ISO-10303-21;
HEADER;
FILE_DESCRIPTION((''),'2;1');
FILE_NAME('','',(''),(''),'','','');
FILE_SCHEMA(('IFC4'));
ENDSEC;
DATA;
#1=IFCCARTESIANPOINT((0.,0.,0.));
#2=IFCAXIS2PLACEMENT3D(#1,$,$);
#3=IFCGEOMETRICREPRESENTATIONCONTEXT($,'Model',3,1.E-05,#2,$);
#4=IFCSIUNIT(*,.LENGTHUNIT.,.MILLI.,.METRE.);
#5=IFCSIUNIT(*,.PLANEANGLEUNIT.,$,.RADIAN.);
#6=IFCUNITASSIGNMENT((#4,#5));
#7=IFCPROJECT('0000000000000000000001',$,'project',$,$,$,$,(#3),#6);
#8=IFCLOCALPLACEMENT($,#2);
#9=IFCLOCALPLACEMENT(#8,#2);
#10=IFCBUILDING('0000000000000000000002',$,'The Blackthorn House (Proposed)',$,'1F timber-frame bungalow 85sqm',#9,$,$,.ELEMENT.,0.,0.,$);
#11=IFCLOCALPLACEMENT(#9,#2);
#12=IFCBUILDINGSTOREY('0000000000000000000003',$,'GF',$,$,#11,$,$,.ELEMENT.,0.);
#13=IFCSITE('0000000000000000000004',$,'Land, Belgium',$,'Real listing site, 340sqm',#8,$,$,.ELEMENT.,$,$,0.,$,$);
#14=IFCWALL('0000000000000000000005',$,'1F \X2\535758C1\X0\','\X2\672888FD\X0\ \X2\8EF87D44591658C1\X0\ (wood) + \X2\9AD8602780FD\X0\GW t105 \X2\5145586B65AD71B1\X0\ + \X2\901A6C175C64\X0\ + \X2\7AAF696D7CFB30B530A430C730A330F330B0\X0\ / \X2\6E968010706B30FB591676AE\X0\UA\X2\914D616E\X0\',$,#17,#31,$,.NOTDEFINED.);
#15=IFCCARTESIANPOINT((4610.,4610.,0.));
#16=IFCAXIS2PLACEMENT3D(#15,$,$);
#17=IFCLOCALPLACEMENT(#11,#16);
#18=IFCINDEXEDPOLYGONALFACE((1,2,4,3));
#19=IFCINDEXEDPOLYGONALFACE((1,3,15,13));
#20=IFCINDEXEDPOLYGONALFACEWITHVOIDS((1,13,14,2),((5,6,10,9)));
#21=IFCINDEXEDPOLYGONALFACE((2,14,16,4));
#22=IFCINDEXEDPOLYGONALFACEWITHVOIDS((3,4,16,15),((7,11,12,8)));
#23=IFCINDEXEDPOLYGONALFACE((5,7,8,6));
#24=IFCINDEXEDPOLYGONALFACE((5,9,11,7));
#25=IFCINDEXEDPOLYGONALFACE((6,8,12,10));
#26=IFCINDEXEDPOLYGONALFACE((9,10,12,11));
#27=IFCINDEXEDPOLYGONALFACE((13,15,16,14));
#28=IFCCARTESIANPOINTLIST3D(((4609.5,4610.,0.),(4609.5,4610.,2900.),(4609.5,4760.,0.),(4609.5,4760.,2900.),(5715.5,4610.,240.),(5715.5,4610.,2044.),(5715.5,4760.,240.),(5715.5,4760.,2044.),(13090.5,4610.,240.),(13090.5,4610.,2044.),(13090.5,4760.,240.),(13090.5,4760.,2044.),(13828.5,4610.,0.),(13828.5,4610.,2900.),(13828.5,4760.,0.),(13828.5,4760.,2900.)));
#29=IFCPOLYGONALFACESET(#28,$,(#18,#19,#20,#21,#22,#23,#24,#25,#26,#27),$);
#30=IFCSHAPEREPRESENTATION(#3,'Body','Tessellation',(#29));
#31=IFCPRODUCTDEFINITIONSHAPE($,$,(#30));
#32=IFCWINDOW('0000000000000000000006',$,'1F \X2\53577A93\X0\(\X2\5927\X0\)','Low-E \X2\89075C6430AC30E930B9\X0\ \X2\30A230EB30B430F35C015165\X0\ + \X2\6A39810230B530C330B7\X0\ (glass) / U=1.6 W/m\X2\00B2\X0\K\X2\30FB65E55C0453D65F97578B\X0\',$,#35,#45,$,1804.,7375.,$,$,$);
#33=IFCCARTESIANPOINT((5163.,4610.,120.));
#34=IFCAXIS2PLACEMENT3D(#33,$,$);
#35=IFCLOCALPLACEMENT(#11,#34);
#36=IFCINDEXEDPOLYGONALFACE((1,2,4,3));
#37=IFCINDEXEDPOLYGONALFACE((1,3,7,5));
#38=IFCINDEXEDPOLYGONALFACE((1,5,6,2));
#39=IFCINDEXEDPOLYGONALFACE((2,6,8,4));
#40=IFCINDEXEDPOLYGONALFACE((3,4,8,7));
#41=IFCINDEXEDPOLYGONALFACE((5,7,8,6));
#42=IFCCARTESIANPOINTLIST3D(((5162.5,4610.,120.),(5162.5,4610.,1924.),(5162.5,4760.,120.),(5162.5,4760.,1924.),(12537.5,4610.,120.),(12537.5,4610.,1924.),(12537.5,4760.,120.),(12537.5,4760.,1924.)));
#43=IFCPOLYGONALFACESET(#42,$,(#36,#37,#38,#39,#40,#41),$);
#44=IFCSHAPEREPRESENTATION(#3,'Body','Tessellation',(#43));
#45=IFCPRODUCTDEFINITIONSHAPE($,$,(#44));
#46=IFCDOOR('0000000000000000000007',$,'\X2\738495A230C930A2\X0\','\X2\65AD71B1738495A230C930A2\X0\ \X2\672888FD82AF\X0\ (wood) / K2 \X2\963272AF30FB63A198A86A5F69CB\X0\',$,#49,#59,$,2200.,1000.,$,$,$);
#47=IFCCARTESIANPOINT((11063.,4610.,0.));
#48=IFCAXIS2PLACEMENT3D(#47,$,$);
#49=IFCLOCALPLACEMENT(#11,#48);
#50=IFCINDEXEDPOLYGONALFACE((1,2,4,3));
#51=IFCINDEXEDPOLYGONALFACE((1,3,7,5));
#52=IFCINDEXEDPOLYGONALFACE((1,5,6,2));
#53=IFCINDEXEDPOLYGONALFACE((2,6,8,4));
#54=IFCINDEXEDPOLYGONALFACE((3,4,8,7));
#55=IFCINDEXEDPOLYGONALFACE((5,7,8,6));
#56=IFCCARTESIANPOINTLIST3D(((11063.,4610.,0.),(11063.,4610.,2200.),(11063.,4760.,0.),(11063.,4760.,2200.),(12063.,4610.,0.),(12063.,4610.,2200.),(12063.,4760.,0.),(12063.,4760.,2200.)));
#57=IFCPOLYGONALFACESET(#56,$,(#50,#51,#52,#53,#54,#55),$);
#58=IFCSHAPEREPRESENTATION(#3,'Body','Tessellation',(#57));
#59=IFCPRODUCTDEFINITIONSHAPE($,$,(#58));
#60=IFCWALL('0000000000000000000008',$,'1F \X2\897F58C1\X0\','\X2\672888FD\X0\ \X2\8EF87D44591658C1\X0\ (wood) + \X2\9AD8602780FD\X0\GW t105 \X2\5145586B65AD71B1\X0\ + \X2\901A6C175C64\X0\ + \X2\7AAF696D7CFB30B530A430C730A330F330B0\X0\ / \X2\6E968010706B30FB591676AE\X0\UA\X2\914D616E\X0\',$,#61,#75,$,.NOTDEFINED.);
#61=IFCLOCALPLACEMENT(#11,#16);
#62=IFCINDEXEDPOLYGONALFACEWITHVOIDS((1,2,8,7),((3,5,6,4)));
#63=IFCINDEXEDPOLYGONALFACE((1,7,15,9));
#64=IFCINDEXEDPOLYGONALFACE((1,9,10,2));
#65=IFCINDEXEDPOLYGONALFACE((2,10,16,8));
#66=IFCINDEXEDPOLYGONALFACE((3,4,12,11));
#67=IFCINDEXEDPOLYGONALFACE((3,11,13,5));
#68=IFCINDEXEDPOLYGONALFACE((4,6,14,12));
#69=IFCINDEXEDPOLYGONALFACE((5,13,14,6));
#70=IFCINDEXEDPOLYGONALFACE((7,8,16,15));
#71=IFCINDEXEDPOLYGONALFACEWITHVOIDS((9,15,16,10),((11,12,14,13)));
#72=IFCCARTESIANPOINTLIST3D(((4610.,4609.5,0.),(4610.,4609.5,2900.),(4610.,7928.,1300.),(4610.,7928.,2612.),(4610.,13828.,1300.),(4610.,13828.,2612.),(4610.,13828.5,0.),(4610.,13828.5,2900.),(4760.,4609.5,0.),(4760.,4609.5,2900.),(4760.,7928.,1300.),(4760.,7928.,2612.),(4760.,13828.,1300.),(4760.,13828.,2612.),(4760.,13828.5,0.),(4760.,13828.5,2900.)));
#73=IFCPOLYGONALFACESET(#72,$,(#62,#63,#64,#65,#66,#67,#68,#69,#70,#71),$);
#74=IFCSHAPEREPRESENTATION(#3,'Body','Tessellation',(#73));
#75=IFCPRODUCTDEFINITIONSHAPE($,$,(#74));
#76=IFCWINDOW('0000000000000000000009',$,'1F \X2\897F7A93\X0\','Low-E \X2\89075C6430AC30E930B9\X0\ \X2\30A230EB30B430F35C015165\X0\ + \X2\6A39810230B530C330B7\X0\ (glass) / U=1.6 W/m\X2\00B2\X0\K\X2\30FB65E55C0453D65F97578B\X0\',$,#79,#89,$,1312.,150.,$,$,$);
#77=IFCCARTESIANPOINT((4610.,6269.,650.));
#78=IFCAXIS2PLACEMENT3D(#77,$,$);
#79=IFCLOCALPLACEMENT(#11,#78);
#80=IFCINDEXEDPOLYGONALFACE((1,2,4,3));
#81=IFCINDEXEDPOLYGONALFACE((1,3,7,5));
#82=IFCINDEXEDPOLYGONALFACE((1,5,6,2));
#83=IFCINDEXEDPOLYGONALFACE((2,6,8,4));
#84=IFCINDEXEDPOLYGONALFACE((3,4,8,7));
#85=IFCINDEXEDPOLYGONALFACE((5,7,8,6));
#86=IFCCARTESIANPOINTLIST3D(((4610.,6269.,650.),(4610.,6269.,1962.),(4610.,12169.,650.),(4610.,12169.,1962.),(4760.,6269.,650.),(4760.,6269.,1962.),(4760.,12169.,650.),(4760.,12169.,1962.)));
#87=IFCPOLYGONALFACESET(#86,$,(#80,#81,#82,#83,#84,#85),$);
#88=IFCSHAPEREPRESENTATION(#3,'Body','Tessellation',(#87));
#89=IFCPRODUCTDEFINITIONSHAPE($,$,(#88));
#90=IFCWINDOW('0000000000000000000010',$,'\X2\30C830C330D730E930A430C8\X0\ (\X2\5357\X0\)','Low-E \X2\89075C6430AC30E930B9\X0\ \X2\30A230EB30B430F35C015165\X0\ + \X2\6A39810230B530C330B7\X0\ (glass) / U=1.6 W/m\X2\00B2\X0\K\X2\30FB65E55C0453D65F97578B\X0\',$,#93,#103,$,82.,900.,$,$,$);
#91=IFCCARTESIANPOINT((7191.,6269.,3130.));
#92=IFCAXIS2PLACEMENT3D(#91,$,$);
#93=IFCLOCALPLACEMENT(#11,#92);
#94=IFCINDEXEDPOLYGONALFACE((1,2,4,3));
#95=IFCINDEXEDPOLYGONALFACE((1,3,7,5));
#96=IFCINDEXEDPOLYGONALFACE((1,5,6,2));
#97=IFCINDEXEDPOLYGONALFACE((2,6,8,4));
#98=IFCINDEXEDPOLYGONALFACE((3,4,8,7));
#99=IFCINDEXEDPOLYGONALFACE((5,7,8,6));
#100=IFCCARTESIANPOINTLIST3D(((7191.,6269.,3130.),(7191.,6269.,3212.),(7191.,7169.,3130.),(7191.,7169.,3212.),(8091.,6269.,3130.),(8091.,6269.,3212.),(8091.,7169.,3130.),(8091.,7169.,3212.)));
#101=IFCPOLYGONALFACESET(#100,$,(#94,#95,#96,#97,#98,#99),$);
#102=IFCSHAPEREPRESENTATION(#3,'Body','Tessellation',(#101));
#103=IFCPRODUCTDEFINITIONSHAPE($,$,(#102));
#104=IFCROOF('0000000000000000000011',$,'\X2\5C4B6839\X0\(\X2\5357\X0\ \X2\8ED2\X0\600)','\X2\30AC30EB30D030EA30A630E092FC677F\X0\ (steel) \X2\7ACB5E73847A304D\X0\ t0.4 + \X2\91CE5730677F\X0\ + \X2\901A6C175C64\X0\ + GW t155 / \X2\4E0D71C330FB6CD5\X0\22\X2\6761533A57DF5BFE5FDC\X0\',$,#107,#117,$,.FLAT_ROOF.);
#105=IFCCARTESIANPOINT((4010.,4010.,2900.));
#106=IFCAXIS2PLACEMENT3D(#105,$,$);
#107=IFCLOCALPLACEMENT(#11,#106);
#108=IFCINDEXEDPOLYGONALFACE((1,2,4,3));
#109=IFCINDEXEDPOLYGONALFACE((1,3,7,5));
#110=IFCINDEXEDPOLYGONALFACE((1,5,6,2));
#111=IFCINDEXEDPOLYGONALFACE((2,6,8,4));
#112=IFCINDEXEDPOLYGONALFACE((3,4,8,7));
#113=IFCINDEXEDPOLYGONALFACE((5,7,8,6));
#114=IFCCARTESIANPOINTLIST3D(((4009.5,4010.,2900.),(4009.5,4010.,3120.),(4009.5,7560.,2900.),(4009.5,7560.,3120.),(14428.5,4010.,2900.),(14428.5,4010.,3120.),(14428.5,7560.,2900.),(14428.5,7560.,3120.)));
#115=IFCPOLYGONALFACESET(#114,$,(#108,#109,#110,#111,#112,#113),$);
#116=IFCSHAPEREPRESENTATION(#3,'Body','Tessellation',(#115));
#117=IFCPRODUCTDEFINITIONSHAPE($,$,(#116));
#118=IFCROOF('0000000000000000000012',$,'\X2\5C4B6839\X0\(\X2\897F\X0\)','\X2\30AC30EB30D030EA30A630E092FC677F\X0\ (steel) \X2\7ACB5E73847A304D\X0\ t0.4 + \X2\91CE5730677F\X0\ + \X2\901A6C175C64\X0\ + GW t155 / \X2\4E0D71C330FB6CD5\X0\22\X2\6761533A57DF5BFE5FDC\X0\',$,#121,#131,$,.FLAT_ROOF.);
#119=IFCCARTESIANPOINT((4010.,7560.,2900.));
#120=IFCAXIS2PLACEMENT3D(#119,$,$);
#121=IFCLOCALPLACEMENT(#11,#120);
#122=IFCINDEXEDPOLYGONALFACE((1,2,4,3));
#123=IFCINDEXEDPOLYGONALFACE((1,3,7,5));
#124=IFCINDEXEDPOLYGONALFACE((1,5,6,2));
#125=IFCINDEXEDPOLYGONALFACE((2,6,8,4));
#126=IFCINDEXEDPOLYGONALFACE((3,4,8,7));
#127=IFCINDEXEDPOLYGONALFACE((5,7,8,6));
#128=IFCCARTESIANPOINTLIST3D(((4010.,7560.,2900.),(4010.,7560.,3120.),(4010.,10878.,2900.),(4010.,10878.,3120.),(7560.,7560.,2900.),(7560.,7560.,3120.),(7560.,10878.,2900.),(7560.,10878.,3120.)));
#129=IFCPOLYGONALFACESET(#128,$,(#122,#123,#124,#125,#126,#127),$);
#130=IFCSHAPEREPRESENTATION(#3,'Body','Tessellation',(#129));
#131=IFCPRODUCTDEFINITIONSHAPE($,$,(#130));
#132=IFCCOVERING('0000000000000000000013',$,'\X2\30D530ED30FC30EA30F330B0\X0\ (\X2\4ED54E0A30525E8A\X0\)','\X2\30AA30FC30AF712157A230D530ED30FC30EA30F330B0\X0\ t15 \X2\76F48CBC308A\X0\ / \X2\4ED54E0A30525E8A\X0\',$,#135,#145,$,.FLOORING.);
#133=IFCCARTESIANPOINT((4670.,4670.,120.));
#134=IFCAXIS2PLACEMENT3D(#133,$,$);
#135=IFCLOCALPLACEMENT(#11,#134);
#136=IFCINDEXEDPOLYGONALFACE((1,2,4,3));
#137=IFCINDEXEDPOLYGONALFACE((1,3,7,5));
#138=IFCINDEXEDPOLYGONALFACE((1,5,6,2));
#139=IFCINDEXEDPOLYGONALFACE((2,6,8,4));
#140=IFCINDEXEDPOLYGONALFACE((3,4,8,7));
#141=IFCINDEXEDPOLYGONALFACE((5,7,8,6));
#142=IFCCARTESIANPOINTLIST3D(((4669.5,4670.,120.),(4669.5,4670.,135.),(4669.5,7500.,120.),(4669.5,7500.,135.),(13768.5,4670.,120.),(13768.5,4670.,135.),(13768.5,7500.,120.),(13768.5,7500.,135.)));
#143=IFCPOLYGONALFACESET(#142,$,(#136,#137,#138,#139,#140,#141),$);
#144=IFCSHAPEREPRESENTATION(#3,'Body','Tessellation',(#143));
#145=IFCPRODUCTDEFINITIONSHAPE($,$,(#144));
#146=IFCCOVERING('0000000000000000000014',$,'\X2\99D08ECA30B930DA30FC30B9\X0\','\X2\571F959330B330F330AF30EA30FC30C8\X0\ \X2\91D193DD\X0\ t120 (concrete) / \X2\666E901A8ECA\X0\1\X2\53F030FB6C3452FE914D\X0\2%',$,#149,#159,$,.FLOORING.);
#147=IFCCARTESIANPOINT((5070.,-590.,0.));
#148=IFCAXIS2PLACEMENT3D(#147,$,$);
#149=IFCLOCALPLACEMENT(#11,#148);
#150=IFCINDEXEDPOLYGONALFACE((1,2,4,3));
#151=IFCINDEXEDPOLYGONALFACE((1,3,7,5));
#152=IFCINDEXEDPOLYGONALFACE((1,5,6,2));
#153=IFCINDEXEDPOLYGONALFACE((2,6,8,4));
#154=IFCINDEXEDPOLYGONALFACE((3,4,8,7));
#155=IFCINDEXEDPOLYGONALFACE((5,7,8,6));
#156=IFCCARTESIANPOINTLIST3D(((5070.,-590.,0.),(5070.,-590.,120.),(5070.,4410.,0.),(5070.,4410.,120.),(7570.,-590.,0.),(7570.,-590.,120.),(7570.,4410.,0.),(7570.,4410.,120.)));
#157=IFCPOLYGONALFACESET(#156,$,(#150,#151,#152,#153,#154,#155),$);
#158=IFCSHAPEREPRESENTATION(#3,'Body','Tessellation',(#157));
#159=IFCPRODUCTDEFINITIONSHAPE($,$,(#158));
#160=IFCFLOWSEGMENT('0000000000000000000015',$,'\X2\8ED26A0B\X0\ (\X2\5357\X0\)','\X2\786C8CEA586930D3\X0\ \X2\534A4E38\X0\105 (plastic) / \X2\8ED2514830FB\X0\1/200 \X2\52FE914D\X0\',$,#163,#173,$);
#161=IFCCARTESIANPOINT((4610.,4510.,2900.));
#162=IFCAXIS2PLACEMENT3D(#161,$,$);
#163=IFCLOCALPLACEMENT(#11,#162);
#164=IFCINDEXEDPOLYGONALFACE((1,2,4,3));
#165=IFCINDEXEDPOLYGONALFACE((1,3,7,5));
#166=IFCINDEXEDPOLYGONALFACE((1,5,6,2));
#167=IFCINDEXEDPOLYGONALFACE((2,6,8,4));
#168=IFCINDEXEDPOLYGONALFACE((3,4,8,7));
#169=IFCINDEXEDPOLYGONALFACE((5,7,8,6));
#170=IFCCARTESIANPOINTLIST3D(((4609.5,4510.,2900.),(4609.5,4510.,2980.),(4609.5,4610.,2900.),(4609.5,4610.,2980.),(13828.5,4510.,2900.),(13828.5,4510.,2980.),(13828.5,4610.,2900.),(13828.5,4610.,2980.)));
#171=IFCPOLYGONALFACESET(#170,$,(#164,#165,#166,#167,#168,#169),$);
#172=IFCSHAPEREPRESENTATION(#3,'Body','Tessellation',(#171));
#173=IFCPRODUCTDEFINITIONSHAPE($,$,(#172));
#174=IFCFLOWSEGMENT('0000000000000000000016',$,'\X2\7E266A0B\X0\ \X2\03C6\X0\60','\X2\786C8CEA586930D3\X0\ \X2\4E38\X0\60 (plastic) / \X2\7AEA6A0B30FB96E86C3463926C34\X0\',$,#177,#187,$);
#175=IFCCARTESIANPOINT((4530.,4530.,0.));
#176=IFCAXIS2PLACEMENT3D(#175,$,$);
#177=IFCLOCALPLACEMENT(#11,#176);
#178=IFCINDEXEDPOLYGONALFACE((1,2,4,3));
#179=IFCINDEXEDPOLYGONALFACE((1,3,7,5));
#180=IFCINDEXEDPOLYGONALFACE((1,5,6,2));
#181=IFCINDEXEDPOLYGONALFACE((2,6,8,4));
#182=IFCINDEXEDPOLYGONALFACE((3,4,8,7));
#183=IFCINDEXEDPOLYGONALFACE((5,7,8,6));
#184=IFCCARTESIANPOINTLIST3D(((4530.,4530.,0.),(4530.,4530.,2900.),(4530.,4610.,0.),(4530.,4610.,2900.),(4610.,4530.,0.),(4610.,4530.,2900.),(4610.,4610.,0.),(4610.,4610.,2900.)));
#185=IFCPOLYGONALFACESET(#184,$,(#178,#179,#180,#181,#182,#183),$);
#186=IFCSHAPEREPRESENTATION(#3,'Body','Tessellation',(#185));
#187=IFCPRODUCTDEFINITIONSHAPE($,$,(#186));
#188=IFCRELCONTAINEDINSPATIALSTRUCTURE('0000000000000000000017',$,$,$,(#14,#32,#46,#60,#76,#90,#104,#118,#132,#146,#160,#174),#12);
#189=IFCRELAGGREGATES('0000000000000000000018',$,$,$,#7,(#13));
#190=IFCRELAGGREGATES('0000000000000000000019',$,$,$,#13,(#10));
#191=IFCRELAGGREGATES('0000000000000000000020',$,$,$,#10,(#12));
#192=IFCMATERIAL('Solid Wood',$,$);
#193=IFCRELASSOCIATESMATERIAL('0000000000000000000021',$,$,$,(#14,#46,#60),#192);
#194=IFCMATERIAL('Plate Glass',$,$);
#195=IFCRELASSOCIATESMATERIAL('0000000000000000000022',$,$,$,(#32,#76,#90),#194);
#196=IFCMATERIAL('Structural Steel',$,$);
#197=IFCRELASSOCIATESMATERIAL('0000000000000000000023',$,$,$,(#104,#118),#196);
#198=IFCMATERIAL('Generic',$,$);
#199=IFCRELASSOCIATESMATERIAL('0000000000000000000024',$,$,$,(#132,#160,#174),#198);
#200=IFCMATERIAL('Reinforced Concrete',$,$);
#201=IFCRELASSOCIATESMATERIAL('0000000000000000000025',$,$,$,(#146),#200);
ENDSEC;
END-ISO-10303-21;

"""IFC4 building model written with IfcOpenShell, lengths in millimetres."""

from ifc_helpers import new_model, si_unit, frame, frame_2d, origin, place, context, project, spatial, rectangle, extrude, material, element, fill, save


model = new_model("IFC4")

# Units and contexts
model_context = context("Model", 3, precision=1e-05, world=origin())
ifc_project = project(units=[si_unit("LENGTHUNIT", "METRE", prefix="MILLI"), si_unit("PLANEANGLEUNIT", "RADIAN")], contexts=[model_context])

# Site, building, storey
site_placement = place(None, origin())
site = spatial("IfcSite", under=ifc_project, at=site_placement, Name="Land, Belgium", ObjectType="Real listing site, 340sqm", CompositionType="ELEMENT", RefElevation=0.0)
building_placement = place(site_placement, origin())
building = spatial("IfcBuilding", under=site, at=building_placement, Name="The Blackthorn House (Proposed)", ObjectType="1F timber-frame bungalow 85sqm", CompositionType="ELEMENT", ElevationOfRefHeight=0.0, ElevationOfTerrain=0.0)
storey_placement = place(building_placement, origin())
storey = spatial("IfcBuildingStorey", under=building, at=storey_placement, Name="GF", CompositionType="ELEMENT", Elevation=0.0)

# Shared definitions
ifc_material_1 = material(Name="Solid Wood")

# Shared definitions
ifc_material_2 = material(Name="Reinforced Concrete")

# Wall, openings, window, door
wall_1_placement = place(storey_placement, frame((4610.0, 4610.0, 0.0)))
wall_1 = element("IfcWall", 1, at=wall_1_placement, inside=storey, material=ifc_material_1, Name="1F 南壁", Description="木製 軸組外壁 (wood) + 高性能GW t105 充填断熱 + 通気層 + 窯業系サイディング / 準耐火・外皮UA配慮", PredefinedType="NOTDEFINED", context=model_context, shape_type="SweptSolid", body=[
    extrude(rectangle(XDim=9219.0, YDim=150.0, at=frame_2d((4609.0, 75.0))), frame((4610.0, 4610.0, 0.0)), (0.0, 0.0, 1.0), 2900.0),
])
opening_1_placement = place(storey_placement, frame((5163.0, 4610.0, 120.0)))
opening_1 = element("IfcOpeningElement", 2, at=opening_1_placement, cuts=wall_1, PredefinedType="NOTDEFINED", context=model_context, shape_type="SweptSolid", body=[
    extrude(rectangle(XDim=7375.0, YDim=150.0, at=frame_2d((3687.0, 75.0))), frame((5163.0, 4610.0, 120.0)), (0.0, 0.0, 1.0), 1804.0),
])
opening_2_placement = place(storey_placement, frame((11063.0, 4610.0, 0.0)))
opening_2 = element("IfcOpeningElement", 3, at=opening_2_placement, cuts=wall_1, PredefinedType="NOTDEFINED", context=model_context, shape_type="SweptSolid", body=[
    extrude(rectangle(XDim=1000.0, YDim=150.0, at=frame_2d((500.0, 75.0))), frame((11063.0, 4610.0, 0.0)), (0.0, 0.0, 1.0), 2200.0),
])
ifc_material_3 = material(Name="Plate Glass")
window_1_placement = place(storey_placement, frame((5163.0, 4610.0, 120.0)))
window_1 = element("IfcWindow", 4, at=window_1_placement, inside=storey, material=ifc_material_3, Name="1F 南窓(大)", Description="Low-E 複層ガラス アルゴン封入 + 樹脂サッシ (glass) / U=1.6 W/m²K・日射取得型", OverallHeight=1804.0, OverallWidth=7375.0, context=model_context, shape_type="SweptSolid", body=[
    extrude(rectangle(XDim=7375.0, YDim=150.0, at=frame_2d((3687.0, 75.0))), frame((5163.0, 4610.0, 120.0)), (0.0, 0.0, 1.0), 1804.0),
])
fill(opening_1, window_1)
door_placement = place(storey_placement, frame((11063.0, 4610.0, 0.0)))
door = element("IfcDoor", 5, at=door_placement, inside=storey, material=ifc_material_1, Name="玄関ドア", Description="断熱玄関ドア 木製芯 (wood) / K2 防犯・採風機構", OverallHeight=2200.0, OverallWidth=1000.0, context=model_context, shape_type="SweptSolid", body=[
    extrude(rectangle(XDim=1000.0, YDim=150.0, at=frame_2d((500.0, 75.0))), frame((11063.0, 4610.0, 0.0)), (0.0, 0.0, 1.0), 2200.0),
])
fill(opening_2, door)

# Wall, opening, window
wall_2_placement = place(storey_placement, frame((4610.0, 4610.0, 0.0)))
wall_2 = element("IfcWall", 6, at=wall_2_placement, inside=storey, material=ifc_material_1, Name="1F 西壁", Description="木製 軸組外壁 (wood) + 高性能GW t105 充填断熱 + 通気層 + 窯業系サイディング / 準耐火・外皮UA配慮", PredefinedType="NOTDEFINED", context=model_context, shape_type="SweptSolid", body=[
    extrude(rectangle(XDim=150.0, YDim=9219.0, at=frame_2d((75.0, 4609.0))), frame((4610.0, 4610.0, 0.0)), (0.0, 0.0, 1.0), 2900.0),
])
opening_3_placement = place(storey_placement, frame((4610.0, 6269.0, 650.0)))
opening_3 = element("IfcOpeningElement", 7, at=opening_3_placement, cuts=wall_2, PredefinedType="NOTDEFINED", context=model_context, shape_type="SweptSolid", body=[
    extrude(rectangle(XDim=150.0, YDim=5900.0, at=frame_2d((75.0, 2950.0))), frame((4610.0, 6269.0, 650.0)), (0.0, 0.0, 1.0), 1312.0),
])
window_2_placement = place(storey_placement, frame((4610.0, 6269.0, 650.0)))
window_2 = element("IfcWindow", 8, at=window_2_placement, inside=storey, material=ifc_material_3, Name="1F 西窓", Description="Low-E 複層ガラス アルゴン封入 + 樹脂サッシ (glass) / U=1.6 W/m²K・日射取得型", OverallHeight=1312.0, OverallWidth=150.0, context=model_context, shape_type="SweptSolid", body=[
    extrude(rectangle(XDim=150.0, YDim=5900.0, at=frame_2d((75.0, 2950.0))), frame((4610.0, 6269.0, 650.0)), (0.0, 0.0, 1.0), 1312.0),
])
fill(opening_3, window_2)

# Window
window_3_placement = place(storey_placement, frame((7191.0, 6269.0, 3130.0)))
element("IfcWindow", 9, at=window_3_placement, inside=storey, material=ifc_material_3, Name="トップライト (南)", Description="Low-E 複層ガラス アルゴン封入 + 樹脂サッシ (glass) / U=1.6 W/m²K・日射取得型", OverallHeight=82.0, OverallWidth=900.0, context=model_context, shape_type="SweptSolid", body=[
    extrude(rectangle(XDim=900.0, YDim=900.0, at=frame_2d((450.0, 450.0))), frame((7191.0, 6269.0, 3130.0)), (0.0, 0.0, 1.0), 82.0),
])

# Roofs
ifc_material_4 = material(Name="Structural Steel")
roof_1_placement = place(storey_placement, frame((4010.0, 4010.0, 2900.0)))
element("IfcRoof", 10, at=roof_1_placement, inside=storey, material=ifc_material_4, Name="屋根(南 軒600)", Description="ガルバリウム鋼板 (steel) 立平葺き t0.4 + 野地板 + 通気層 + GW t155 / 不燃・法22条区域対応", PredefinedType="FLAT_ROOF", context=model_context, shape_type="SweptSolid", body=[
    extrude(rectangle(XDim=10419.0, YDim=3550.0, at=frame_2d((5209.0, 1775.0))), frame((4010.0, 4010.0, 2900.0)), (0.0, 0.0, 1.0), 220.0),
])
roof_2_placement = place(storey_placement, frame((4010.0, 7560.0, 2900.0)))
element("IfcRoof", 11, at=roof_2_placement, inside=storey, material=ifc_material_4, Name="屋根(西)", Description="ガルバリウム鋼板 (steel) 立平葺き t0.4 + 野地板 + 通気層 + GW t155 / 不燃・法22条区域対応", PredefinedType="FLAT_ROOF", context=model_context, shape_type="SweptSolid", body=[
    extrude(rectangle(XDim=3550.0, YDim=3318.0, at=frame_2d((1775.0, 1659.0))), frame((4010.0, 7560.0, 2900.0)), (0.0, 0.0, 1.0), 220.0),
])

# Coverings
ifc_material_5 = material(Name="Generic")
covering_1_placement = place(storey_placement, frame((4670.0, 4670.0, 120.0)))
element("IfcCovering", 12, at=covering_1_placement, inside=storey, material=ifc_material_5, Name="フローリング (仕上げ床)", Description="オーク無垢フローリング t15 直貼り / 仕上げ床", PredefinedType="FLOORING", context=model_context, shape_type="SweptSolid", body=[
    extrude(rectangle(XDim=9099.0, YDim=2830.0, at=frame_2d((4549.0, 1415.0))), frame((4670.0, 4670.0, 120.0)), (0.0, 0.0, 1.0), 15.0),
])
covering_2_placement = place(storey_placement, frame((5070.0, -590.0, 0.0)))
element("IfcCovering", 13, at=covering_2_placement, inside=storey, material=ifc_material_2, Name="駐車スペース", Description="土間コンクリート 金鏝 t120 (concrete) / 普通車1台・水勾配2%", PredefinedType="FLOORING", context=model_context, shape_type="SweptSolid", body=[
    extrude(rectangle(XDim=2500.0, YDim=5000.0, at=frame_2d((1250.0, 2500.0))), frame((5070.0, -590.0, 0.0)), (0.0, 0.0, 1.0), 120.0),
])

# Flow segments
flow_segment_1_placement = place(storey_placement, frame((4610.0, 4510.0, 2900.0)))
element("IfcFlowSegment", 14, at=flow_segment_1_placement, inside=storey, material=ifc_material_5, Name="軒樋 (南)", Description="硬質塩ビ 半丸105 (plastic) / 軒先・1/200 勾配", context=model_context, shape_type="SweptSolid", body=[
    extrude(rectangle(XDim=9219.0, YDim=100.0, at=frame_2d((4609.0, 50.0))), frame((4610.0, 4510.0, 2900.0)), (0.0, 0.0, 1.0), 80.0),
])
flow_segment_2_placement = place(storey_placement, frame((4530.0, 4530.0, 0.0)))
element("IfcFlowSegment", 15, at=flow_segment_2_placement, inside=storey, material=ifc_material_5, Name="縦樋 φ60", Description="硬質塩ビ 丸60 (plastic) / 竪樋・雨水排水", context=model_context, shape_type="SweptSolid", body=[
    extrude(rectangle(XDim=80.0, YDim=80.0, at=frame_2d((40.0, 40.0))), frame((4530.0, 4530.0, 0.0)), (0.0, 0.0, 1.0), 2900.0),
])

save(model, "model.ifc")
